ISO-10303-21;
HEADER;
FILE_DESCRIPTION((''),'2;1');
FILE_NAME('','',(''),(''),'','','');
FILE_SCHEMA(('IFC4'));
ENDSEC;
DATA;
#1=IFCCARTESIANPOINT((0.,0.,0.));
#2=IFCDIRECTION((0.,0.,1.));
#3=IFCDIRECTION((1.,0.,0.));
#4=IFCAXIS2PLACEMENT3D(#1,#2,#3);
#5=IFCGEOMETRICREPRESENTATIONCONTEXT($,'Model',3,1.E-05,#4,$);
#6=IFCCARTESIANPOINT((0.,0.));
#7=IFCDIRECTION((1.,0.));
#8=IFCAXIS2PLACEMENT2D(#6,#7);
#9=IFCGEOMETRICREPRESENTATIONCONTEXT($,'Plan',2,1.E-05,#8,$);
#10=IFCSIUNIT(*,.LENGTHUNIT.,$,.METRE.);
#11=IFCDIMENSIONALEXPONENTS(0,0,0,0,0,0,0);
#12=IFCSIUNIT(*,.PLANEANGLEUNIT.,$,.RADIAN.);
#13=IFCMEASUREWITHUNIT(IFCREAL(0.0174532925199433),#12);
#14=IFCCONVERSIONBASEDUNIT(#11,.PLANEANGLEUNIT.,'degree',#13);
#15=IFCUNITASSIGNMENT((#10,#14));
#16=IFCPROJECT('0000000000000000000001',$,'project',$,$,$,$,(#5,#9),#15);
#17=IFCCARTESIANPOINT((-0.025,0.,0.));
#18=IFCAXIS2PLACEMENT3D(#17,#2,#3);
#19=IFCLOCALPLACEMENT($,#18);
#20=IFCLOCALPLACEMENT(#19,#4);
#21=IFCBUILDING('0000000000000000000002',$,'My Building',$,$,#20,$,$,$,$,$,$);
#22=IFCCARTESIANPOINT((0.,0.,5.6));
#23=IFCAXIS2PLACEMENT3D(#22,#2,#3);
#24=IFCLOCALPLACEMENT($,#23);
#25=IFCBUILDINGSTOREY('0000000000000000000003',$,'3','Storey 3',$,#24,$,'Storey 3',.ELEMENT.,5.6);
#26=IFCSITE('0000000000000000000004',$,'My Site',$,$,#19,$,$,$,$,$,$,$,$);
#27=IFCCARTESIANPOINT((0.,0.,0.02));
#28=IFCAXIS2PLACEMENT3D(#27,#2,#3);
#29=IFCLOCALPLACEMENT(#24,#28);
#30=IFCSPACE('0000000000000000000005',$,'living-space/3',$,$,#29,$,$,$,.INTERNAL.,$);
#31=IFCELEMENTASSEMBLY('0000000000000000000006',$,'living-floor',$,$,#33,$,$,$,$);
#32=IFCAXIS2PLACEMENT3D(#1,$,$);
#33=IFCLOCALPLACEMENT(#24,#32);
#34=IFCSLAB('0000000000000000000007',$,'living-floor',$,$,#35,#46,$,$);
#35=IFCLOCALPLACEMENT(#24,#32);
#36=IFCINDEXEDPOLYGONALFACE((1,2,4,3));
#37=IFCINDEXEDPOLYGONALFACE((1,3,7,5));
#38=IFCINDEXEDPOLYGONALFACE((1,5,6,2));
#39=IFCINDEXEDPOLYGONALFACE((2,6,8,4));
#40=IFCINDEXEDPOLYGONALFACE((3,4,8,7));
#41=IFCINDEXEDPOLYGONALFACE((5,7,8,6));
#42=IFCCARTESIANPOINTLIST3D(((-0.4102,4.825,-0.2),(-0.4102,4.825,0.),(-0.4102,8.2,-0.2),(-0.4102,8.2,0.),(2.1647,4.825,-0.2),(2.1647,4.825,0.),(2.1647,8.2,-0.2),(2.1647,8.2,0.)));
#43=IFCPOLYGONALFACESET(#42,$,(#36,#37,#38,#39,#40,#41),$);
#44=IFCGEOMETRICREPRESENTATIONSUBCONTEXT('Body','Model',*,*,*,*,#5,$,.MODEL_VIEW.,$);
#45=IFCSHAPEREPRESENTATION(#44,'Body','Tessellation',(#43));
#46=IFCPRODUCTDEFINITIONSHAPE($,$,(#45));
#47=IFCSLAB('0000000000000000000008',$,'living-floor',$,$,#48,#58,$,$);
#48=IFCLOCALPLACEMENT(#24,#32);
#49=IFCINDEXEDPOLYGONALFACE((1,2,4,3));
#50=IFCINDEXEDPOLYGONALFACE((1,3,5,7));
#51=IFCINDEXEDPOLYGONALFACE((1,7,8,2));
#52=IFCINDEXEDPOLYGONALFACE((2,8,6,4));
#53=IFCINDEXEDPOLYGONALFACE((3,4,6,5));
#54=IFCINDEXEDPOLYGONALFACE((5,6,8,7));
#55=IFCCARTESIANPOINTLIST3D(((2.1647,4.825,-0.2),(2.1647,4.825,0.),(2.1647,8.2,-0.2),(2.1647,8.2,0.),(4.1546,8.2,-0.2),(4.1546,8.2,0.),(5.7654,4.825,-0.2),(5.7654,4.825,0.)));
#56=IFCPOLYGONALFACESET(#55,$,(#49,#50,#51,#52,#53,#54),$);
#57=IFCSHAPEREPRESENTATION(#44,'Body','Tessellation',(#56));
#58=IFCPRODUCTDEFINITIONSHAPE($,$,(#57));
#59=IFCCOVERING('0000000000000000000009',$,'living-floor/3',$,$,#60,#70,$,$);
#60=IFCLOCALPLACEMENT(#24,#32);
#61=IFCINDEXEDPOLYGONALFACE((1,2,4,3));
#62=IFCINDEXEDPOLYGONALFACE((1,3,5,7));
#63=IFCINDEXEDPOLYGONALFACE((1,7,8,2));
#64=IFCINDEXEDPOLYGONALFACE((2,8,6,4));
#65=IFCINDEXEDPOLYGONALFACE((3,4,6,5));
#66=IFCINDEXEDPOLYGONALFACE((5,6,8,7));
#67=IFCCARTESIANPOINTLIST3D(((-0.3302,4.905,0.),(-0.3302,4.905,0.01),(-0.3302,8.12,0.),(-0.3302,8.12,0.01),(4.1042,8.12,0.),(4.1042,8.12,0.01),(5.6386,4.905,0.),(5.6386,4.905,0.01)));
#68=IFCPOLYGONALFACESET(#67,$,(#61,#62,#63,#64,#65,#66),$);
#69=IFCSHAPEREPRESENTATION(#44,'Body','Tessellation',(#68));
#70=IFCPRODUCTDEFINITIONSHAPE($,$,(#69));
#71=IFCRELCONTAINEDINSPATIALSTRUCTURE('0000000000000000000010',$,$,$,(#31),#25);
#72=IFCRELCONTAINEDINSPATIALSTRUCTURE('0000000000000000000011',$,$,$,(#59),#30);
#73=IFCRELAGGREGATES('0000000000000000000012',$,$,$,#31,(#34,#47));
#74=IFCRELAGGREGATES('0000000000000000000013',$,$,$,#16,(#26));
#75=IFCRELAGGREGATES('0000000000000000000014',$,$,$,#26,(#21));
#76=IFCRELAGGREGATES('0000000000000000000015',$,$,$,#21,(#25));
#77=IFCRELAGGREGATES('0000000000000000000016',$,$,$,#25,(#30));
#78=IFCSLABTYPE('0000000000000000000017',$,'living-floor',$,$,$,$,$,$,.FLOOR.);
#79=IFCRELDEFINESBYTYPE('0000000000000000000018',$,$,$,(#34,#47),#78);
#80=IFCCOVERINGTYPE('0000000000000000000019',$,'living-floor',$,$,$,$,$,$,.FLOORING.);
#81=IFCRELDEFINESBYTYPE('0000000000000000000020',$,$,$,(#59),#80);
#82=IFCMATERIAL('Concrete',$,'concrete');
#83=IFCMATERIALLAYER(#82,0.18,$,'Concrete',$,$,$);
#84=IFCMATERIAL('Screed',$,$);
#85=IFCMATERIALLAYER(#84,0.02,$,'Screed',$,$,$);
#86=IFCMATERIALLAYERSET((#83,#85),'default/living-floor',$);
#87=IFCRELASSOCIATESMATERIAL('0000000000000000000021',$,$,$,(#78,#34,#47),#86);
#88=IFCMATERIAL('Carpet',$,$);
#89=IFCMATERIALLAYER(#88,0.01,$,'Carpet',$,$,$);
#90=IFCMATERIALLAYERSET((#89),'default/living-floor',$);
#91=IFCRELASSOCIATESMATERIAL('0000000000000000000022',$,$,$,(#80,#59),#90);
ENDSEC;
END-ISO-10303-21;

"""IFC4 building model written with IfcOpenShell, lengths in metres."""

from ifc_helpers import new_model, entity, si_unit, converted_unit, frame, origin, origin_with_axes, origin_2d_with_axis, place, context, subcontext, project, spatial, polyline, outline, extrude, material, layer, layer_set, layer_usage, type_object, element, aggregate, save


model = new_model("IFC4")

# Units and contexts
model_context = context("Model", 3, precision=1e-05, world=origin_with_axes())
plan_context = context("Plan", 2, precision=1e-05, world=origin_2d_with_axis())
body_context = subcontext(model_context, "Body", "Model", "MODEL_VIEW")
ifc_project = project(units=[si_unit("LENGTHUNIT", "METRE"), converted_unit("PLANEANGLEUNIT", "degree", entity("IfcReal", 0.0174532925199433), si_unit("PLANEANGLEUNIT", "RADIAN"), dimensions=[0, 0, 0, 0, 0, 0, 0])], contexts=[model_context, plan_context])

# Site, building, storey
site_placement = place(None, frame((-0.025, 0.0, 0.0), z_axis=(0.0, 0.0, 1.0), x_axis=(1.0, 0.0, 0.0)))
site = spatial("IfcSite", under=ifc_project, at=site_placement, Name="My Site")
building_placement = place(site_placement, origin_with_axes())
building = spatial("IfcBuilding", under=site, at=building_placement, Name="My Building")
storey_placement = place(None, frame((0.0, 0.0, 5.6), z_axis=(0.0, 0.0, 1.0), x_axis=(1.0, 0.0, 0.0)))
storey = spatial("IfcBuildingStorey", under=building, at=storey_placement, Name="3", Description="Storey 3", LongName="Storey 3", CompositionType="ELEMENT", Elevation=5.6)

# Element assembly, slabs
assembly_placement = place(storey_placement, frame((0.0, 0.0, -5.6), z_axis=(0.0, 0.0, 1.0), x_axis=(1.0, 0.0, 0.0)))
assembly = element("IfcElementAssembly", 1, at=assembly_placement, inside=storey, Name="living-floor")
ifc_material_1 = material(Name="Concrete", Category="concrete")
ifc_layer_1 = layer(ifc_material_1, 0.18, Name="Concrete")
ifc_material_2 = material(Name="Screed")
ifc_layer_2 = layer(ifc_material_2, 0.02, Name="Screed")
ifc_layer_set_1 = layer_set([ifc_layer_1, ifc_layer_2], Name="default/living-floor")
ifc_layer_usage_1 = layer_usage(ifc_layer_set_1, "AXIS3", "POSITIVE", 0.0)
slab_type = type_object("IfcSlabType", Name="living-floor", PredefinedType="FLOOR", material=ifc_layer_set_1)
slab_1_placement = place(assembly_placement, frame((2.1647, 8.2, 5.4), z_axis=(0.0, 0.0, 1.0), x_axis=(1.0, 0.0, 0.0)))
slab_1 = element("IfcSlab", 2, at=slab_1_placement, type_object=slab_type, material=ifc_layer_usage_1, Name="living-floor", context=body_context, shape_type="SweptSolid", body=[
    extrude(outline(polyline([(0.0, 0.0), (0.0, -3.375), (-2.5749, -3.375), (-2.5749, 0.0), (0.0, 0.0)])), origin(), (0.0, 0.0, 1.0), 0.2),
])
ifc_layer_usage_2 = layer_usage(ifc_layer_set_1, "AXIS3", "POSITIVE", 0.0)
slab_2_placement = place(assembly_placement, frame((2.1647, 8.2, 5.4), z_axis=(0.0, 0.0, 1.0), x_axis=(1.0, 0.0, 0.0)))
slab_2 = element("IfcSlab", 3, at=slab_2_placement, type_object=slab_type, material=ifc_layer_usage_2, Name="living-floor", context=body_context, shape_type="SweptSolid", body=[
    extrude(outline(polyline([(0.0, 0.0), (1.99, 0.0), (3.6007, -3.375), (0.0, -3.375), (0.0, 0.0)])), origin(), (0.0, 0.0, 1.0), 0.2),
])
aggregate(assembly, [slab_1, slab_2])

# Shared definitions
space_placement = place(storey_placement, frame((0.0, 0.0, 0.02), z_axis=(0.0, 0.0, 1.0), x_axis=(1.0, 0.0, 0.0)))
space = spatial("IfcSpace", under=storey, at=space_placement, Name="living-space/3", PredefinedType="INTERNAL")

# Covering
ifc_material_3 = material(Name="Carpet")
ifc_layer_3 = layer(ifc_material_3, 0.01, Name="Carpet")
ifc_layer_set_2 = layer_set([ifc_layer_3], Name="default/living-floor")
ifc_layer_usage_3 = layer_usage(ifc_layer_set_2, "AXIS2", "POSITIVE", 0.0)
covering_type = type_object("IfcCoveringType", Name="living-floor", PredefinedType="FLOORING", material=ifc_layer_set_2)
covering_placement = place(space_placement, frame((0.0, 0.0, -0.02), z_axis=(0.0, 0.0, 1.0), x_axis=(1.0, 0.0, 0.0)))
element("IfcCovering", 4, at=covering_placement, inside=space, type_object=covering_type, material=ifc_layer_usage_3, Name="living-floor/3", context=body_context, shape_type="SweptSolid", body=[
    extrude(outline(polyline([(5.6386, 4.905), (4.1042, 8.12), (-0.3302, 8.12), (-0.3302, 4.905), (5.6386, 4.905)])), origin_with_axes(), (0.0, 0.0, 1.0), 0.01),
])

save(model, "model.ifc")
